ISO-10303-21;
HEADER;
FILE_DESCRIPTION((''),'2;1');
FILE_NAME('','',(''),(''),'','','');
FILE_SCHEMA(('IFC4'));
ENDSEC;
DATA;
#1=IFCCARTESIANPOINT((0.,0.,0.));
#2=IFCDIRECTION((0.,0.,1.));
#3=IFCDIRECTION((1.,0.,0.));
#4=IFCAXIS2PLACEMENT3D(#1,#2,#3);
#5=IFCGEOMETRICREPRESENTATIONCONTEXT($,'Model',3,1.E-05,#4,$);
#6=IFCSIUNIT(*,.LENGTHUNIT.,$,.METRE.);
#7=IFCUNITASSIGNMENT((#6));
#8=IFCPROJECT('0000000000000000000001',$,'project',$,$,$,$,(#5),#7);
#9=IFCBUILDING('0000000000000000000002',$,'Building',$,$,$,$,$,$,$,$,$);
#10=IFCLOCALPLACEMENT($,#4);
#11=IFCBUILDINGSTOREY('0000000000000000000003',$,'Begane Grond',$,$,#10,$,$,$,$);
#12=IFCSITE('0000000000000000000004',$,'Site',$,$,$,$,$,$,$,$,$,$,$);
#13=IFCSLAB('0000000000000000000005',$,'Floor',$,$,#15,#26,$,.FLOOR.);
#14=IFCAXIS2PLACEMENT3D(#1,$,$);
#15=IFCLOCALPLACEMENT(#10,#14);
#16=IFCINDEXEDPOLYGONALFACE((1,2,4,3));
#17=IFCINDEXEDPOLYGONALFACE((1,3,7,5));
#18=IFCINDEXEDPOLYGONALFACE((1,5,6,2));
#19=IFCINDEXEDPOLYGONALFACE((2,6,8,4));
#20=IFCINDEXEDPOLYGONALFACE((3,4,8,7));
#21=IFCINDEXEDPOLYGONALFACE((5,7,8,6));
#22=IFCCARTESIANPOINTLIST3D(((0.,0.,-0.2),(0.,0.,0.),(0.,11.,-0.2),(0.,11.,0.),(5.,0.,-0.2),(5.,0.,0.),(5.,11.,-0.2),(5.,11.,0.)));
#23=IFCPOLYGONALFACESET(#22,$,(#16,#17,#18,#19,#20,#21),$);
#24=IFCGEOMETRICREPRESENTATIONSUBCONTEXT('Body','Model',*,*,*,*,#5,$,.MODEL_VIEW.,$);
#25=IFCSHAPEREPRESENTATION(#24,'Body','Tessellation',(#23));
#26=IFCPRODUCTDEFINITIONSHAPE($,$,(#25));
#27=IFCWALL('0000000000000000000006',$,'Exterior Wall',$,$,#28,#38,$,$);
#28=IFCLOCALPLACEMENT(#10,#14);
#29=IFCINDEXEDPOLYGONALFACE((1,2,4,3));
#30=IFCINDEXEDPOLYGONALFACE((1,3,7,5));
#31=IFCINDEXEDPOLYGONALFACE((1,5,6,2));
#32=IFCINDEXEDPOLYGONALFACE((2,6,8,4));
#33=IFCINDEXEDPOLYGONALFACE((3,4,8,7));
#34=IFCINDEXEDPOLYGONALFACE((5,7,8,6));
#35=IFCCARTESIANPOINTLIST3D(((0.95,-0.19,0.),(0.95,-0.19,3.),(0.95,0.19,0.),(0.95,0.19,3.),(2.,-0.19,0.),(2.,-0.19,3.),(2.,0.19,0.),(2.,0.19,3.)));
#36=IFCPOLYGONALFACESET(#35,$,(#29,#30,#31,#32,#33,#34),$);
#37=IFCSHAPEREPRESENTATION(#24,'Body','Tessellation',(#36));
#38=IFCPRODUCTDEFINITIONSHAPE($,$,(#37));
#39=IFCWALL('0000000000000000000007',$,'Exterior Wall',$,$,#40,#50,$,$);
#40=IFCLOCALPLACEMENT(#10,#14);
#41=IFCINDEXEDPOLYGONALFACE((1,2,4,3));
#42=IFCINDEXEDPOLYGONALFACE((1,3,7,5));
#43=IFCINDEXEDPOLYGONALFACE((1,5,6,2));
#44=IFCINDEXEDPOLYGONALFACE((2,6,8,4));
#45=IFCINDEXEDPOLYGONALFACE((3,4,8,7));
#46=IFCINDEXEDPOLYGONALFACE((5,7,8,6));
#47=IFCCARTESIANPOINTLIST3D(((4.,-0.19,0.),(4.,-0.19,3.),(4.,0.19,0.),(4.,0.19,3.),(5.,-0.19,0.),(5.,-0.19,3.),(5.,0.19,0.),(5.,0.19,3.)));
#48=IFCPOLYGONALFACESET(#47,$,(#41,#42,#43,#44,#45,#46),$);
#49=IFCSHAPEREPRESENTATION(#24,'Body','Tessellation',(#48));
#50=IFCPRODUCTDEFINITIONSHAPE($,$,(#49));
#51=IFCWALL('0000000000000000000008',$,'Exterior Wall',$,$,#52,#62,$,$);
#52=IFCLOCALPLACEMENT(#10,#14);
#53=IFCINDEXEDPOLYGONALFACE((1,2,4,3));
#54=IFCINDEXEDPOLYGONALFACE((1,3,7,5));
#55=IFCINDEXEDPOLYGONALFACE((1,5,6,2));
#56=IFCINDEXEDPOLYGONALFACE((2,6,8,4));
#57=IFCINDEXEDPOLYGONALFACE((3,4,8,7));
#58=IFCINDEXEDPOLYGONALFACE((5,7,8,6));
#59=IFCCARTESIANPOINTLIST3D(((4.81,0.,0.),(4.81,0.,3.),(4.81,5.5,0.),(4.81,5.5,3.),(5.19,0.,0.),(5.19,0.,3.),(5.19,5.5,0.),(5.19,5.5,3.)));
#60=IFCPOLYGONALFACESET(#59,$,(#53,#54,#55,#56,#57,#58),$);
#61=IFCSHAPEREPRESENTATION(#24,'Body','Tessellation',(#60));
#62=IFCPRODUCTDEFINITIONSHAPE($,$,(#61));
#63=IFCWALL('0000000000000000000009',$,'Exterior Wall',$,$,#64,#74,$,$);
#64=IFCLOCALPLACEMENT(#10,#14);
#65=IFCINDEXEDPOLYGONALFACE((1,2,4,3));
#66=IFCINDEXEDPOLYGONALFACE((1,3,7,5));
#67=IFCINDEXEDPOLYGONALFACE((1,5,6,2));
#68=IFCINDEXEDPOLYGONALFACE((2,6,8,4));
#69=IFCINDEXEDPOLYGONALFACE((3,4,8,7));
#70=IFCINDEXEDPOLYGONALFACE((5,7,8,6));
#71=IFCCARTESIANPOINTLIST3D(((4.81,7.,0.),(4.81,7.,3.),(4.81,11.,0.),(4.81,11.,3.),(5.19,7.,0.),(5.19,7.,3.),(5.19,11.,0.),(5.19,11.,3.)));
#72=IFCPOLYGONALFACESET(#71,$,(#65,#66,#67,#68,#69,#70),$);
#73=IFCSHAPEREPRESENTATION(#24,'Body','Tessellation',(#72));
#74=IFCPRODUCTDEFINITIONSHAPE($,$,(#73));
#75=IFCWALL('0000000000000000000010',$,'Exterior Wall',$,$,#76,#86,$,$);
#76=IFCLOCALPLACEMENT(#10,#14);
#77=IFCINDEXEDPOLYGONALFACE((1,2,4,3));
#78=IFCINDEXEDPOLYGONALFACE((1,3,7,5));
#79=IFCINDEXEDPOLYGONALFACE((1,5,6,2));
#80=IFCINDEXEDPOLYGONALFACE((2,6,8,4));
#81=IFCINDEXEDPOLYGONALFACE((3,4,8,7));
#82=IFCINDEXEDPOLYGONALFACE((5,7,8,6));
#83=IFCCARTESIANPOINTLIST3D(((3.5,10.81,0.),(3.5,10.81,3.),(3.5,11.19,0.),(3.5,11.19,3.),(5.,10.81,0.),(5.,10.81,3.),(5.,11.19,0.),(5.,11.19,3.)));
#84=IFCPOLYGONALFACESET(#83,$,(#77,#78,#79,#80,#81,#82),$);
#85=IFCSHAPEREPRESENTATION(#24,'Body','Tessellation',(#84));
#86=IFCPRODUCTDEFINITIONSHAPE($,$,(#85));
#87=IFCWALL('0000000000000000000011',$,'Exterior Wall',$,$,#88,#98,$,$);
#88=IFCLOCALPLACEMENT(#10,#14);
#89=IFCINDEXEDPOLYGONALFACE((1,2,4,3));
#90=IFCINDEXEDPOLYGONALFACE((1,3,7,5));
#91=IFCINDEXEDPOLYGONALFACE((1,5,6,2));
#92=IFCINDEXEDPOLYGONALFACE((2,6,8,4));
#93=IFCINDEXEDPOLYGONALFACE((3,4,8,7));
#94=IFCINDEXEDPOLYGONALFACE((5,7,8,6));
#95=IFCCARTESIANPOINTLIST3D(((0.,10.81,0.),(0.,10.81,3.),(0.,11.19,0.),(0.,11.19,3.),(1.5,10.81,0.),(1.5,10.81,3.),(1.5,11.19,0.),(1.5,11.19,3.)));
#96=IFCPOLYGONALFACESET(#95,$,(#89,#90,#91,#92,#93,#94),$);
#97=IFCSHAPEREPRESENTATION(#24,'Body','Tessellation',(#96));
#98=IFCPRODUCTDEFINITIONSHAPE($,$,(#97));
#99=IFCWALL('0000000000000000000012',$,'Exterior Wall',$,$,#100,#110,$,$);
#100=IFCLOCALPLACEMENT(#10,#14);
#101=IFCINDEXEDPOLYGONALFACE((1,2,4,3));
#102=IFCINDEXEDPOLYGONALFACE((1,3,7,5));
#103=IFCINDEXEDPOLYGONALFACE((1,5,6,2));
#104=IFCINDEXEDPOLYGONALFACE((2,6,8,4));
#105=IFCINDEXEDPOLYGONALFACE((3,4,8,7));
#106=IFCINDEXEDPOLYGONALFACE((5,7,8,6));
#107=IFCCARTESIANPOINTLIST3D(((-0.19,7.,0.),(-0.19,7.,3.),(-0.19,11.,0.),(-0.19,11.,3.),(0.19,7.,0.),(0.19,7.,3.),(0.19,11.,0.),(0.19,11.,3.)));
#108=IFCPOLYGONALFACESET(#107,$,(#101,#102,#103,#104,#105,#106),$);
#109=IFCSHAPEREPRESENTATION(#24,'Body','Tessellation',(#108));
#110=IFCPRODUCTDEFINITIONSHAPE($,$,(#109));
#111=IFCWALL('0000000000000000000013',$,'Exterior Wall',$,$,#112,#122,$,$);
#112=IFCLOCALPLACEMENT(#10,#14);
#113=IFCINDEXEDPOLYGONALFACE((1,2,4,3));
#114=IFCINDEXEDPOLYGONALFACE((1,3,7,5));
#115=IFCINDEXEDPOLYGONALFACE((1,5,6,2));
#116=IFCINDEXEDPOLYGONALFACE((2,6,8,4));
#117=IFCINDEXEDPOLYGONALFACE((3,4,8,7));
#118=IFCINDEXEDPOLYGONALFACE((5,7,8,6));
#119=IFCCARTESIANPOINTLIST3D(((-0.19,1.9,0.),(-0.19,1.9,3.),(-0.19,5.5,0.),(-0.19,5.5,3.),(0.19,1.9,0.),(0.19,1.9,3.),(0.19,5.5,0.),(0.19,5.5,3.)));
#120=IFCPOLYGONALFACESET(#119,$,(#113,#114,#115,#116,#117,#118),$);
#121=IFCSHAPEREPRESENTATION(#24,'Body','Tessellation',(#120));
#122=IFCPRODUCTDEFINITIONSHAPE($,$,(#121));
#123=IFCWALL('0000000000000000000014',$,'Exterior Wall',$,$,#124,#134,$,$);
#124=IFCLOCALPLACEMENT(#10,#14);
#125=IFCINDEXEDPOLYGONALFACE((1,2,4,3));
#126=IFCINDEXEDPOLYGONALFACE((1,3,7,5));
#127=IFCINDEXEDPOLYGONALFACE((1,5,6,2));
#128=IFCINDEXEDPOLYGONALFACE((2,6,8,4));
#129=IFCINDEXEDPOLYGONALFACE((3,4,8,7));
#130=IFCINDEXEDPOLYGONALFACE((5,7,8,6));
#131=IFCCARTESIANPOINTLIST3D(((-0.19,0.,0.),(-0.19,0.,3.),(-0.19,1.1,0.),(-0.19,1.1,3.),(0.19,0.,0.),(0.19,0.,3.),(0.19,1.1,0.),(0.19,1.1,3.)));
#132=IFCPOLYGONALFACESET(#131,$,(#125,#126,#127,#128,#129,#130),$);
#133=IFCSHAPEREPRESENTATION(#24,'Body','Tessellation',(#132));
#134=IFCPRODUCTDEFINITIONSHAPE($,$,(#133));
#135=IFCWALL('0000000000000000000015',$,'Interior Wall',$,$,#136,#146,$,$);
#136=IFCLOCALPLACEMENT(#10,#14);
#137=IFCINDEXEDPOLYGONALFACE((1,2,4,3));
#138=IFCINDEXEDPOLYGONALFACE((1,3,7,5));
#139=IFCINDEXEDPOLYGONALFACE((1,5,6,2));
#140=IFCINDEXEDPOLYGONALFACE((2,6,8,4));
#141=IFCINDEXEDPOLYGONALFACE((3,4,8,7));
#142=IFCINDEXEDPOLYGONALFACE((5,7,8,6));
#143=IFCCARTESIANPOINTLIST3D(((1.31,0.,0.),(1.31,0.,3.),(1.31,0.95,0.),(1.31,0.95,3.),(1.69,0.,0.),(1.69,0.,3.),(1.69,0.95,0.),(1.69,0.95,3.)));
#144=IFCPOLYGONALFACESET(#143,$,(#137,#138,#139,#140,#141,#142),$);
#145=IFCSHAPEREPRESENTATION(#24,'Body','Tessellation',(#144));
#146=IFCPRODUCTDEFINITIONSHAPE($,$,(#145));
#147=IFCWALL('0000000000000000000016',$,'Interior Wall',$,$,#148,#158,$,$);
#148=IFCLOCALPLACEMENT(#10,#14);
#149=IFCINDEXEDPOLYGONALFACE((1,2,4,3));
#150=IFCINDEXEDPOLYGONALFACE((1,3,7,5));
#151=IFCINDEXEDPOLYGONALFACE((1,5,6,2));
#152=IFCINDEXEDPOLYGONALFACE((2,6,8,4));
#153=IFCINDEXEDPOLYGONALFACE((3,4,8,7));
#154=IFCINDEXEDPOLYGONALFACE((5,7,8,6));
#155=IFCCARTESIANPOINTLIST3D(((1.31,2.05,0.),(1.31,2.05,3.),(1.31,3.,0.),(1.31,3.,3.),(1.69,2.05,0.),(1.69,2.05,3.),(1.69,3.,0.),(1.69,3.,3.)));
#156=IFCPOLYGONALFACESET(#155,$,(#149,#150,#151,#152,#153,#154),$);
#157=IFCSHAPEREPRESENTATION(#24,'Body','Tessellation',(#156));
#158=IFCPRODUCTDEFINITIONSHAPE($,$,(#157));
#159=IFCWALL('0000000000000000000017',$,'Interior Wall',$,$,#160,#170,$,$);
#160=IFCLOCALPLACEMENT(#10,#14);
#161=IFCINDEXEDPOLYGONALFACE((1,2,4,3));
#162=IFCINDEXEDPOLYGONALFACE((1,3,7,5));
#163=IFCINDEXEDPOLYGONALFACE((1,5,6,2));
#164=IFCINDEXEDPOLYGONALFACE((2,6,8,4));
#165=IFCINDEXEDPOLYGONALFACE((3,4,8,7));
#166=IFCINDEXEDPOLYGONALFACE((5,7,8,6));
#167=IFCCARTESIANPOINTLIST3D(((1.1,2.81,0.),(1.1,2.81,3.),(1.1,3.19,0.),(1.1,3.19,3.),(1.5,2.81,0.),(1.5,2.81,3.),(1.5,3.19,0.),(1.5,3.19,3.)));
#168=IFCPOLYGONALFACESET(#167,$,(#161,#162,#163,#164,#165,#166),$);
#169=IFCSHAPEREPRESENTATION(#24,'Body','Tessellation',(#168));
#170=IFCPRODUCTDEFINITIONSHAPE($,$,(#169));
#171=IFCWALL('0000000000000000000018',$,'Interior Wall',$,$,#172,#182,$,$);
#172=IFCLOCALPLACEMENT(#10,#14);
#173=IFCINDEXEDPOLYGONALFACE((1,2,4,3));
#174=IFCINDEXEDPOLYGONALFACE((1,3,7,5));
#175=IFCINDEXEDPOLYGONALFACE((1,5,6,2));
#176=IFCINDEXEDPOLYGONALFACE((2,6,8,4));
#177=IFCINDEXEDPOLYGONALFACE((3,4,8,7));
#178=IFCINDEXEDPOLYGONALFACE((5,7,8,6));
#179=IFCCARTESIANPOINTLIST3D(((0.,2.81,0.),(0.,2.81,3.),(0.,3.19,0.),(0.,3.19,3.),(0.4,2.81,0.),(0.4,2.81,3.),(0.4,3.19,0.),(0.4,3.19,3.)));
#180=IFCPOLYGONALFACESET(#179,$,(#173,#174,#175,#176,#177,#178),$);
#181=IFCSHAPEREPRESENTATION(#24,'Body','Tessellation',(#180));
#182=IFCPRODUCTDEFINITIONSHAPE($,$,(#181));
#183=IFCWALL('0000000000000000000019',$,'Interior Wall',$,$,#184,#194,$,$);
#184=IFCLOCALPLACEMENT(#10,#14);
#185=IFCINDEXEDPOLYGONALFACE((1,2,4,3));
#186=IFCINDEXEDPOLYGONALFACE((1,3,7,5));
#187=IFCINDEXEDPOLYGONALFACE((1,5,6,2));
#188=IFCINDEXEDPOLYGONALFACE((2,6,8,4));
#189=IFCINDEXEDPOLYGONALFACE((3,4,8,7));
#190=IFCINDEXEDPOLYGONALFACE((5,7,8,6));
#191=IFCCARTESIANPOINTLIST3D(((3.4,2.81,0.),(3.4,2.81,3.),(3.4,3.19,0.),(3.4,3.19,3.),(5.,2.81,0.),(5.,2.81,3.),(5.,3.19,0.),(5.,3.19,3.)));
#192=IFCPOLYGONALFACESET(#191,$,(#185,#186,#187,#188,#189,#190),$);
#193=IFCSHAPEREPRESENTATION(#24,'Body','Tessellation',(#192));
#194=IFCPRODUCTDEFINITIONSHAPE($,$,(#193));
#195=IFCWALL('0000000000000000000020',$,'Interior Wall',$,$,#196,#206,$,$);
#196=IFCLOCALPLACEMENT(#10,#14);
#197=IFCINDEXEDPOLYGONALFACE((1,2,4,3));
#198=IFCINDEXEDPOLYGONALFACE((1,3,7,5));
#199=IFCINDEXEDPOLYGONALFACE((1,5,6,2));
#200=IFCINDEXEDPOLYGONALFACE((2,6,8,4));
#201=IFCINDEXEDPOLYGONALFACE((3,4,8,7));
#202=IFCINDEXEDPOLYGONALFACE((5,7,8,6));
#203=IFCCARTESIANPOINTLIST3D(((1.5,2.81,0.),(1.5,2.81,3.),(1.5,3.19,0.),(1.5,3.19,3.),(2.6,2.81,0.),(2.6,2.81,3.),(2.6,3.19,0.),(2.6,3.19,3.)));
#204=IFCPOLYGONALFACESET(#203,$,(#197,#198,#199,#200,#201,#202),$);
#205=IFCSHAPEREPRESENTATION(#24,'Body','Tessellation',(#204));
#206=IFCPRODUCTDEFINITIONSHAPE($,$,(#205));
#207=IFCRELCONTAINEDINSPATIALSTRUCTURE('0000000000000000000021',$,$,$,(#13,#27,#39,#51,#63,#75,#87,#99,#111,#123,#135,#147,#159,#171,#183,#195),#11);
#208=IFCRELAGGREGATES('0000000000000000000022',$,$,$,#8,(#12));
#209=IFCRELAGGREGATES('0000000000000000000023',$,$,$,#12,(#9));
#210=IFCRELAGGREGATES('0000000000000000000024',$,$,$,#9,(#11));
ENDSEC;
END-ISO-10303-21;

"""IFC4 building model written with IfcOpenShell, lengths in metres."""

from ifc_helpers import new_model, si_unit, frame, origin_with_axes, place, context, subcontext, project, spatial, indexed_curve, outline, extrude, element, save


model = new_model("IFC4")

# Units and contexts
model_context = context("Model", 3, precision=1e-05, world=origin_with_axes())
body_context = subcontext(model_context, "Body", "Model", "MODEL_VIEW")
ifc_project = project(units=[si_unit("LENGTHUNIT", "METRE")], contexts=[model_context])

# Site, building, storey
site = spatial("IfcSite", under=ifc_project, Name="Site")
building = spatial("IfcBuilding", under=site, Name="Building")
storey_placement = place(None, origin_with_axes())
storey = spatial("IfcBuildingStorey", under=building, at=storey_placement, Name="Begane Grond")

# Slab
slab_placement = place(storey_placement, frame((0.0, 0.0, -0.2), z_axis=(0.0, 0.0, 1.0), x_axis=(1.0, 0.0, 0.0)))
element("IfcSlab", 1, at=slab_placement, inside=storey, Name="Floor", PredefinedType="FLOOR", context=body_context, shape_type="SweptSolid", body=[
    extrude(outline(indexed_curve([(0.0, 0.0), (5.0, 0.0), (5.0, 11.0), (0.0, 11.0)])), None, (0.0, 0.0, 1.0), 0.2),
])

# Walls
wall_1_placement = place(storey_placement, frame((0.95, 0.0, 0.0), z_axis=(0.0, 0.0, 1.0), x_axis=(1.0, 0.0, 0.0)))
element("IfcWall", 2, at=wall_1_placement, inside=storey, Name="Exterior Wall", context=body_context, shape_type="SweptSolid", body=[
    extrude(outline(indexed_curve([(0.0, 0.0), (0.0, 0.38), (1.05, 0.38), (1.05, 0.0), (0.0, 0.0)], self_intersect=False)), frame((0.0, -0.19, 0.0), z_axis=(0.0, 0.0, 1.0), x_axis=(1.0, 0.0, 0.0)), (0.0, 0.0, 1.0), 3.0),
])
wall_2_placement = place(storey_placement, frame((4.0, 0.0, 0.0), z_axis=(0.0, 0.0, 1.0), x_axis=(1.0, 0.0, 0.0)))
element("IfcWall", 3, at=wall_2_placement, inside=storey, Name="Exterior Wall", context=body_context, shape_type="SweptSolid", body=[
    extrude(outline(indexed_curve([(0.0, 0.0), (0.0, 0.38), (1.0, 0.38), (1.0, 0.0), (0.0, 0.0)], self_intersect=False)), frame((0.0, -0.19, 0.0), z_axis=(0.0, 0.0, 1.0), x_axis=(1.0, 0.0, 0.0)), (0.0, 0.0, 1.0), 3.0),
])
wall_3_placement = place(storey_placement, frame((5.0, 0.0, 0.0), z_axis=(0.0, 0.0, 1.0), x_axis=(0.0, 1.0, 0.0)))
element("IfcWall", 4, at=wall_3_placement, inside=storey, Name="Exterior Wall", context=body_context, shape_type="SweptSolid", body=[
    extrude(outline(indexed_curve([(0.0, 0.0), (0.0, 0.38), (5.5, 0.38), (5.5, 0.0), (0.0, 0.0)], self_intersect=False)), frame((0.0, -0.19, 0.0), z_axis=(0.0, 0.0, 1.0), x_axis=(1.0, 0.0, 0.0)), (0.0, 0.0, 1.0), 3.0),
])
wall_4_placement = place(storey_placement, frame((5.0, 7.0, 0.0), z_axis=(0.0, 0.0, 1.0), x_axis=(0.0, 1.0, 0.0)))
element("IfcWall", 5, at=wall_4_placement, inside=storey, Name="Exterior Wall", context=body_context, shape_type="SweptSolid", body=[
    extrude(outline(indexed_curve([(0.0, 0.0), (0.0, 0.38), (4.0, 0.38), (4.0, 0.0), (0.0, 0.0)], self_intersect=False)), frame((0.0, -0.19, 0.0), z_axis=(0.0, 0.0, 1.0), x_axis=(1.0, 0.0, 0.0)), (0.0, 0.0, 1.0), 3.0),
])
for number, where, z_axis, x_axis, name in (
    (6, (5.0, 11.0, 0.0), (0.0, 0.0, 1.0), (-1.0, 0.0, 0.0), "Exterior Wall"),
    (7, (1.5, 11.0, 0.0), (0.0, 0.0, 1.0), (-1.0, 0.0, 0.0), "Exterior Wall"),
):
    element("IfcWall", number, at=place(storey_placement, frame(where, z_axis=z_axis, x_axis=x_axis)), inside=storey, Name=name, context=body_context, shape_type="SweptSolid", body=[
        extrude(outline(indexed_curve([(0.0, 0.0), (0.0, 0.38), (1.5, 0.38), (1.5, 0.0), (0.0, 0.0)], self_intersect=False)), frame((0.0, -0.19, 0.0), z_axis=(0.0, 0.0, 1.0), x_axis=(1.0, 0.0, 0.0)), (0.0, 0.0, 1.0), 3.0),
    ])
wall_5_placement = place(storey_placement, frame((0.0, 11.0, 0.0), z_axis=(0.0, 0.0, 1.0), x_axis=(0.0, -1.0, 0.0)))
element("IfcWall", 8, at=wall_5_placement, inside=storey, Name="Exterior Wall", context=body_context, shape_type="SweptSolid", body=[
    extrude(outline(indexed_curve([(0.0, 0.0), (0.0, 0.38), (4.0, 0.38), (4.0, 0.0), (0.0, 0.0)], self_intersect=False)), frame((0.0, -0.19, 0.0), z_axis=(0.0, 0.0, 1.0), x_axis=(1.0, 0.0, 0.0)), (0.0, 0.0, 1.0), 3.0),
])
wall_6_placement = place(storey_placement, frame((0.0, 5.5, 0.0), z_axis=(0.0, 0.0, 1.0), x_axis=(0.0, -1.0, 0.0)))
element("IfcWall", 9, at=wall_6_placement, inside=storey, Name="Exterior Wall", context=body_context, shape_type="SweptSolid", body=[
    extrude(outline(indexed_curve([(0.0, 0.0), (0.0, 0.38), (3.6, 0.38), (3.6, 0.0), (0.0, 0.0)], self_intersect=False)), frame((0.0, -0.19, 0.0), z_axis=(0.0, 0.0, 1.0), x_axis=(1.0, 0.0, 0.0)), (0.0, 0.0, 1.0), 3.0),
])
wall_7_placement = place(storey_placement, frame((0.0, 1.1, 0.0), z_axis=(0.0, 0.0, 1.0), x_axis=(0.0, -1.0, 0.0)))
element("IfcWall", 10, at=wall_7_placement, inside=storey, Name="Exterior Wall", context=body_context, shape_type="SweptSolid", body=[
    extrude(outline(indexed_curve([(0.0, 0.0), (0.0, 0.38), (1.1, 0.38), (1.1, 0.0), (0.0, 0.0)], self_intersect=False)), frame((0.0, -0.19, 0.0), z_axis=(0.0, 0.0, 1.0), x_axis=(1.0, 0.0, 0.0)), (0.0, 0.0, 1.0), 3.0),
])
wall_8_placement = place(storey_placement, frame((1.5, 0.0, 0.0), z_axis=(0.0, 0.0, 1.0), x_axis=(0.0, 1.0, 0.0)))
element("IfcWall", 11, at=wall_8_placement, inside=storey, Name="Interior Wall", context=body_context, shape_type="SweptSolid", body=[
    extrude(outline(indexed_curve([(0.0, 0.0), (0.0, 0.38), (0.95, 0.38), (0.95, 0.0), (0.0, 0.0)], self_intersect=False)), frame((0.0, -0.19, 0.0), z_axis=(0.0, 0.0, 1.0), x_axis=(1.0, 0.0, 0.0)), (0.0, 0.0, 1.0), 3.0),
])
wall_9_placement = place(storey_placement, frame((1.5, 2.05, 0.0), z_axis=(0.0, 0.0, 1.0), x_axis=(0.0, 1.0, 0.0)))
element("IfcWall", 12, at=wall_9_placement, inside=storey, Name="Interior Wall", context=body_context, shape_type="SweptSolid", body=[
    extrude(outline(indexed_curve([(0.0, 0.0), (0.0, 0.38), (0.95, 0.38), (0.95, 0.0), (0.0, 0.0)], self_intersect=False)), frame((0.0, -0.19, 0.0), z_axis=(0.0, 0.0, 1.0), x_axis=(1.0, 0.0, 0.0)), (0.0, 0.0, 1.0), 3.0),
])
for number, where, z_axis, x_axis, name in (
    (13, (1.5, 3.0, 0.0), (0.0, 0.0, 1.0), (-1.0, 0.0, 0.0), "Interior Wall"),
    (14, (0.4, 3.0, 0.0), (0.0, 0.0, 1.0), (-1.0, 0.0, 0.0), "Interior Wall"),
):
    element("IfcWall", number, at=place(storey_placement, frame(where, z_axis=z_axis, x_axis=x_axis)), inside=storey, Name=name, context=body_context, shape_type="SweptSolid", body=[
        extrude(outline(indexed_curve([(0.0, 0.0), (0.0, 0.38), (0.4, 0.38), (0.4, 0.0), (0.0, 0.0)], self_intersect=False)), frame((0.0, -0.19, 0.0), z_axis=(0.0, 0.0, 1.0), x_axis=(1.0, 0.0, 0.0)), (0.0, 0.0, 1.0), 3.0),
    ])
wall_10_placement = place(storey_placement, frame((5.0, 3.0, 0.0), z_axis=(0.0, 0.0, 1.0), x_axis=(-1.0, 0.0, 0.0)))
element("IfcWall", 15, at=wall_10_placement, inside=storey, Name="Interior Wall", context=body_context, shape_type="SweptSolid", body=[
    extrude(outline(indexed_curve([(0.0, 0.0), (0.0, 0.38), (1.6, 0.38), (1.6, 0.0), (0.0, 0.0)], self_intersect=False)), frame((0.0, -0.19, 0.0), z_axis=(0.0, 0.0, 1.0), x_axis=(1.0, 0.0, 0.0)), (0.0, 0.0, 1.0), 3.0),
])
wall_11_placement = place(storey_placement, frame((2.6, 3.0, 0.0), z_axis=(0.0, 0.0, 1.0), x_axis=(-1.0, 0.0, 0.0)))
element("IfcWall", 16, at=wall_11_placement, inside=storey, Name="Interior Wall", context=body_context, shape_type="SweptSolid", body=[
    extrude(outline(indexed_curve([(0.0, 0.0), (0.0, 0.38), (1.1, 0.38), (1.1, 0.0), (0.0, 0.0)], self_intersect=False)), frame((0.0, -0.19, 0.0), z_axis=(0.0, 0.0, 1.0), x_axis=(1.0, 0.0, 0.0)), (0.0, 0.0, 1.0), 3.0),
])

save(model, "model.ifc")
